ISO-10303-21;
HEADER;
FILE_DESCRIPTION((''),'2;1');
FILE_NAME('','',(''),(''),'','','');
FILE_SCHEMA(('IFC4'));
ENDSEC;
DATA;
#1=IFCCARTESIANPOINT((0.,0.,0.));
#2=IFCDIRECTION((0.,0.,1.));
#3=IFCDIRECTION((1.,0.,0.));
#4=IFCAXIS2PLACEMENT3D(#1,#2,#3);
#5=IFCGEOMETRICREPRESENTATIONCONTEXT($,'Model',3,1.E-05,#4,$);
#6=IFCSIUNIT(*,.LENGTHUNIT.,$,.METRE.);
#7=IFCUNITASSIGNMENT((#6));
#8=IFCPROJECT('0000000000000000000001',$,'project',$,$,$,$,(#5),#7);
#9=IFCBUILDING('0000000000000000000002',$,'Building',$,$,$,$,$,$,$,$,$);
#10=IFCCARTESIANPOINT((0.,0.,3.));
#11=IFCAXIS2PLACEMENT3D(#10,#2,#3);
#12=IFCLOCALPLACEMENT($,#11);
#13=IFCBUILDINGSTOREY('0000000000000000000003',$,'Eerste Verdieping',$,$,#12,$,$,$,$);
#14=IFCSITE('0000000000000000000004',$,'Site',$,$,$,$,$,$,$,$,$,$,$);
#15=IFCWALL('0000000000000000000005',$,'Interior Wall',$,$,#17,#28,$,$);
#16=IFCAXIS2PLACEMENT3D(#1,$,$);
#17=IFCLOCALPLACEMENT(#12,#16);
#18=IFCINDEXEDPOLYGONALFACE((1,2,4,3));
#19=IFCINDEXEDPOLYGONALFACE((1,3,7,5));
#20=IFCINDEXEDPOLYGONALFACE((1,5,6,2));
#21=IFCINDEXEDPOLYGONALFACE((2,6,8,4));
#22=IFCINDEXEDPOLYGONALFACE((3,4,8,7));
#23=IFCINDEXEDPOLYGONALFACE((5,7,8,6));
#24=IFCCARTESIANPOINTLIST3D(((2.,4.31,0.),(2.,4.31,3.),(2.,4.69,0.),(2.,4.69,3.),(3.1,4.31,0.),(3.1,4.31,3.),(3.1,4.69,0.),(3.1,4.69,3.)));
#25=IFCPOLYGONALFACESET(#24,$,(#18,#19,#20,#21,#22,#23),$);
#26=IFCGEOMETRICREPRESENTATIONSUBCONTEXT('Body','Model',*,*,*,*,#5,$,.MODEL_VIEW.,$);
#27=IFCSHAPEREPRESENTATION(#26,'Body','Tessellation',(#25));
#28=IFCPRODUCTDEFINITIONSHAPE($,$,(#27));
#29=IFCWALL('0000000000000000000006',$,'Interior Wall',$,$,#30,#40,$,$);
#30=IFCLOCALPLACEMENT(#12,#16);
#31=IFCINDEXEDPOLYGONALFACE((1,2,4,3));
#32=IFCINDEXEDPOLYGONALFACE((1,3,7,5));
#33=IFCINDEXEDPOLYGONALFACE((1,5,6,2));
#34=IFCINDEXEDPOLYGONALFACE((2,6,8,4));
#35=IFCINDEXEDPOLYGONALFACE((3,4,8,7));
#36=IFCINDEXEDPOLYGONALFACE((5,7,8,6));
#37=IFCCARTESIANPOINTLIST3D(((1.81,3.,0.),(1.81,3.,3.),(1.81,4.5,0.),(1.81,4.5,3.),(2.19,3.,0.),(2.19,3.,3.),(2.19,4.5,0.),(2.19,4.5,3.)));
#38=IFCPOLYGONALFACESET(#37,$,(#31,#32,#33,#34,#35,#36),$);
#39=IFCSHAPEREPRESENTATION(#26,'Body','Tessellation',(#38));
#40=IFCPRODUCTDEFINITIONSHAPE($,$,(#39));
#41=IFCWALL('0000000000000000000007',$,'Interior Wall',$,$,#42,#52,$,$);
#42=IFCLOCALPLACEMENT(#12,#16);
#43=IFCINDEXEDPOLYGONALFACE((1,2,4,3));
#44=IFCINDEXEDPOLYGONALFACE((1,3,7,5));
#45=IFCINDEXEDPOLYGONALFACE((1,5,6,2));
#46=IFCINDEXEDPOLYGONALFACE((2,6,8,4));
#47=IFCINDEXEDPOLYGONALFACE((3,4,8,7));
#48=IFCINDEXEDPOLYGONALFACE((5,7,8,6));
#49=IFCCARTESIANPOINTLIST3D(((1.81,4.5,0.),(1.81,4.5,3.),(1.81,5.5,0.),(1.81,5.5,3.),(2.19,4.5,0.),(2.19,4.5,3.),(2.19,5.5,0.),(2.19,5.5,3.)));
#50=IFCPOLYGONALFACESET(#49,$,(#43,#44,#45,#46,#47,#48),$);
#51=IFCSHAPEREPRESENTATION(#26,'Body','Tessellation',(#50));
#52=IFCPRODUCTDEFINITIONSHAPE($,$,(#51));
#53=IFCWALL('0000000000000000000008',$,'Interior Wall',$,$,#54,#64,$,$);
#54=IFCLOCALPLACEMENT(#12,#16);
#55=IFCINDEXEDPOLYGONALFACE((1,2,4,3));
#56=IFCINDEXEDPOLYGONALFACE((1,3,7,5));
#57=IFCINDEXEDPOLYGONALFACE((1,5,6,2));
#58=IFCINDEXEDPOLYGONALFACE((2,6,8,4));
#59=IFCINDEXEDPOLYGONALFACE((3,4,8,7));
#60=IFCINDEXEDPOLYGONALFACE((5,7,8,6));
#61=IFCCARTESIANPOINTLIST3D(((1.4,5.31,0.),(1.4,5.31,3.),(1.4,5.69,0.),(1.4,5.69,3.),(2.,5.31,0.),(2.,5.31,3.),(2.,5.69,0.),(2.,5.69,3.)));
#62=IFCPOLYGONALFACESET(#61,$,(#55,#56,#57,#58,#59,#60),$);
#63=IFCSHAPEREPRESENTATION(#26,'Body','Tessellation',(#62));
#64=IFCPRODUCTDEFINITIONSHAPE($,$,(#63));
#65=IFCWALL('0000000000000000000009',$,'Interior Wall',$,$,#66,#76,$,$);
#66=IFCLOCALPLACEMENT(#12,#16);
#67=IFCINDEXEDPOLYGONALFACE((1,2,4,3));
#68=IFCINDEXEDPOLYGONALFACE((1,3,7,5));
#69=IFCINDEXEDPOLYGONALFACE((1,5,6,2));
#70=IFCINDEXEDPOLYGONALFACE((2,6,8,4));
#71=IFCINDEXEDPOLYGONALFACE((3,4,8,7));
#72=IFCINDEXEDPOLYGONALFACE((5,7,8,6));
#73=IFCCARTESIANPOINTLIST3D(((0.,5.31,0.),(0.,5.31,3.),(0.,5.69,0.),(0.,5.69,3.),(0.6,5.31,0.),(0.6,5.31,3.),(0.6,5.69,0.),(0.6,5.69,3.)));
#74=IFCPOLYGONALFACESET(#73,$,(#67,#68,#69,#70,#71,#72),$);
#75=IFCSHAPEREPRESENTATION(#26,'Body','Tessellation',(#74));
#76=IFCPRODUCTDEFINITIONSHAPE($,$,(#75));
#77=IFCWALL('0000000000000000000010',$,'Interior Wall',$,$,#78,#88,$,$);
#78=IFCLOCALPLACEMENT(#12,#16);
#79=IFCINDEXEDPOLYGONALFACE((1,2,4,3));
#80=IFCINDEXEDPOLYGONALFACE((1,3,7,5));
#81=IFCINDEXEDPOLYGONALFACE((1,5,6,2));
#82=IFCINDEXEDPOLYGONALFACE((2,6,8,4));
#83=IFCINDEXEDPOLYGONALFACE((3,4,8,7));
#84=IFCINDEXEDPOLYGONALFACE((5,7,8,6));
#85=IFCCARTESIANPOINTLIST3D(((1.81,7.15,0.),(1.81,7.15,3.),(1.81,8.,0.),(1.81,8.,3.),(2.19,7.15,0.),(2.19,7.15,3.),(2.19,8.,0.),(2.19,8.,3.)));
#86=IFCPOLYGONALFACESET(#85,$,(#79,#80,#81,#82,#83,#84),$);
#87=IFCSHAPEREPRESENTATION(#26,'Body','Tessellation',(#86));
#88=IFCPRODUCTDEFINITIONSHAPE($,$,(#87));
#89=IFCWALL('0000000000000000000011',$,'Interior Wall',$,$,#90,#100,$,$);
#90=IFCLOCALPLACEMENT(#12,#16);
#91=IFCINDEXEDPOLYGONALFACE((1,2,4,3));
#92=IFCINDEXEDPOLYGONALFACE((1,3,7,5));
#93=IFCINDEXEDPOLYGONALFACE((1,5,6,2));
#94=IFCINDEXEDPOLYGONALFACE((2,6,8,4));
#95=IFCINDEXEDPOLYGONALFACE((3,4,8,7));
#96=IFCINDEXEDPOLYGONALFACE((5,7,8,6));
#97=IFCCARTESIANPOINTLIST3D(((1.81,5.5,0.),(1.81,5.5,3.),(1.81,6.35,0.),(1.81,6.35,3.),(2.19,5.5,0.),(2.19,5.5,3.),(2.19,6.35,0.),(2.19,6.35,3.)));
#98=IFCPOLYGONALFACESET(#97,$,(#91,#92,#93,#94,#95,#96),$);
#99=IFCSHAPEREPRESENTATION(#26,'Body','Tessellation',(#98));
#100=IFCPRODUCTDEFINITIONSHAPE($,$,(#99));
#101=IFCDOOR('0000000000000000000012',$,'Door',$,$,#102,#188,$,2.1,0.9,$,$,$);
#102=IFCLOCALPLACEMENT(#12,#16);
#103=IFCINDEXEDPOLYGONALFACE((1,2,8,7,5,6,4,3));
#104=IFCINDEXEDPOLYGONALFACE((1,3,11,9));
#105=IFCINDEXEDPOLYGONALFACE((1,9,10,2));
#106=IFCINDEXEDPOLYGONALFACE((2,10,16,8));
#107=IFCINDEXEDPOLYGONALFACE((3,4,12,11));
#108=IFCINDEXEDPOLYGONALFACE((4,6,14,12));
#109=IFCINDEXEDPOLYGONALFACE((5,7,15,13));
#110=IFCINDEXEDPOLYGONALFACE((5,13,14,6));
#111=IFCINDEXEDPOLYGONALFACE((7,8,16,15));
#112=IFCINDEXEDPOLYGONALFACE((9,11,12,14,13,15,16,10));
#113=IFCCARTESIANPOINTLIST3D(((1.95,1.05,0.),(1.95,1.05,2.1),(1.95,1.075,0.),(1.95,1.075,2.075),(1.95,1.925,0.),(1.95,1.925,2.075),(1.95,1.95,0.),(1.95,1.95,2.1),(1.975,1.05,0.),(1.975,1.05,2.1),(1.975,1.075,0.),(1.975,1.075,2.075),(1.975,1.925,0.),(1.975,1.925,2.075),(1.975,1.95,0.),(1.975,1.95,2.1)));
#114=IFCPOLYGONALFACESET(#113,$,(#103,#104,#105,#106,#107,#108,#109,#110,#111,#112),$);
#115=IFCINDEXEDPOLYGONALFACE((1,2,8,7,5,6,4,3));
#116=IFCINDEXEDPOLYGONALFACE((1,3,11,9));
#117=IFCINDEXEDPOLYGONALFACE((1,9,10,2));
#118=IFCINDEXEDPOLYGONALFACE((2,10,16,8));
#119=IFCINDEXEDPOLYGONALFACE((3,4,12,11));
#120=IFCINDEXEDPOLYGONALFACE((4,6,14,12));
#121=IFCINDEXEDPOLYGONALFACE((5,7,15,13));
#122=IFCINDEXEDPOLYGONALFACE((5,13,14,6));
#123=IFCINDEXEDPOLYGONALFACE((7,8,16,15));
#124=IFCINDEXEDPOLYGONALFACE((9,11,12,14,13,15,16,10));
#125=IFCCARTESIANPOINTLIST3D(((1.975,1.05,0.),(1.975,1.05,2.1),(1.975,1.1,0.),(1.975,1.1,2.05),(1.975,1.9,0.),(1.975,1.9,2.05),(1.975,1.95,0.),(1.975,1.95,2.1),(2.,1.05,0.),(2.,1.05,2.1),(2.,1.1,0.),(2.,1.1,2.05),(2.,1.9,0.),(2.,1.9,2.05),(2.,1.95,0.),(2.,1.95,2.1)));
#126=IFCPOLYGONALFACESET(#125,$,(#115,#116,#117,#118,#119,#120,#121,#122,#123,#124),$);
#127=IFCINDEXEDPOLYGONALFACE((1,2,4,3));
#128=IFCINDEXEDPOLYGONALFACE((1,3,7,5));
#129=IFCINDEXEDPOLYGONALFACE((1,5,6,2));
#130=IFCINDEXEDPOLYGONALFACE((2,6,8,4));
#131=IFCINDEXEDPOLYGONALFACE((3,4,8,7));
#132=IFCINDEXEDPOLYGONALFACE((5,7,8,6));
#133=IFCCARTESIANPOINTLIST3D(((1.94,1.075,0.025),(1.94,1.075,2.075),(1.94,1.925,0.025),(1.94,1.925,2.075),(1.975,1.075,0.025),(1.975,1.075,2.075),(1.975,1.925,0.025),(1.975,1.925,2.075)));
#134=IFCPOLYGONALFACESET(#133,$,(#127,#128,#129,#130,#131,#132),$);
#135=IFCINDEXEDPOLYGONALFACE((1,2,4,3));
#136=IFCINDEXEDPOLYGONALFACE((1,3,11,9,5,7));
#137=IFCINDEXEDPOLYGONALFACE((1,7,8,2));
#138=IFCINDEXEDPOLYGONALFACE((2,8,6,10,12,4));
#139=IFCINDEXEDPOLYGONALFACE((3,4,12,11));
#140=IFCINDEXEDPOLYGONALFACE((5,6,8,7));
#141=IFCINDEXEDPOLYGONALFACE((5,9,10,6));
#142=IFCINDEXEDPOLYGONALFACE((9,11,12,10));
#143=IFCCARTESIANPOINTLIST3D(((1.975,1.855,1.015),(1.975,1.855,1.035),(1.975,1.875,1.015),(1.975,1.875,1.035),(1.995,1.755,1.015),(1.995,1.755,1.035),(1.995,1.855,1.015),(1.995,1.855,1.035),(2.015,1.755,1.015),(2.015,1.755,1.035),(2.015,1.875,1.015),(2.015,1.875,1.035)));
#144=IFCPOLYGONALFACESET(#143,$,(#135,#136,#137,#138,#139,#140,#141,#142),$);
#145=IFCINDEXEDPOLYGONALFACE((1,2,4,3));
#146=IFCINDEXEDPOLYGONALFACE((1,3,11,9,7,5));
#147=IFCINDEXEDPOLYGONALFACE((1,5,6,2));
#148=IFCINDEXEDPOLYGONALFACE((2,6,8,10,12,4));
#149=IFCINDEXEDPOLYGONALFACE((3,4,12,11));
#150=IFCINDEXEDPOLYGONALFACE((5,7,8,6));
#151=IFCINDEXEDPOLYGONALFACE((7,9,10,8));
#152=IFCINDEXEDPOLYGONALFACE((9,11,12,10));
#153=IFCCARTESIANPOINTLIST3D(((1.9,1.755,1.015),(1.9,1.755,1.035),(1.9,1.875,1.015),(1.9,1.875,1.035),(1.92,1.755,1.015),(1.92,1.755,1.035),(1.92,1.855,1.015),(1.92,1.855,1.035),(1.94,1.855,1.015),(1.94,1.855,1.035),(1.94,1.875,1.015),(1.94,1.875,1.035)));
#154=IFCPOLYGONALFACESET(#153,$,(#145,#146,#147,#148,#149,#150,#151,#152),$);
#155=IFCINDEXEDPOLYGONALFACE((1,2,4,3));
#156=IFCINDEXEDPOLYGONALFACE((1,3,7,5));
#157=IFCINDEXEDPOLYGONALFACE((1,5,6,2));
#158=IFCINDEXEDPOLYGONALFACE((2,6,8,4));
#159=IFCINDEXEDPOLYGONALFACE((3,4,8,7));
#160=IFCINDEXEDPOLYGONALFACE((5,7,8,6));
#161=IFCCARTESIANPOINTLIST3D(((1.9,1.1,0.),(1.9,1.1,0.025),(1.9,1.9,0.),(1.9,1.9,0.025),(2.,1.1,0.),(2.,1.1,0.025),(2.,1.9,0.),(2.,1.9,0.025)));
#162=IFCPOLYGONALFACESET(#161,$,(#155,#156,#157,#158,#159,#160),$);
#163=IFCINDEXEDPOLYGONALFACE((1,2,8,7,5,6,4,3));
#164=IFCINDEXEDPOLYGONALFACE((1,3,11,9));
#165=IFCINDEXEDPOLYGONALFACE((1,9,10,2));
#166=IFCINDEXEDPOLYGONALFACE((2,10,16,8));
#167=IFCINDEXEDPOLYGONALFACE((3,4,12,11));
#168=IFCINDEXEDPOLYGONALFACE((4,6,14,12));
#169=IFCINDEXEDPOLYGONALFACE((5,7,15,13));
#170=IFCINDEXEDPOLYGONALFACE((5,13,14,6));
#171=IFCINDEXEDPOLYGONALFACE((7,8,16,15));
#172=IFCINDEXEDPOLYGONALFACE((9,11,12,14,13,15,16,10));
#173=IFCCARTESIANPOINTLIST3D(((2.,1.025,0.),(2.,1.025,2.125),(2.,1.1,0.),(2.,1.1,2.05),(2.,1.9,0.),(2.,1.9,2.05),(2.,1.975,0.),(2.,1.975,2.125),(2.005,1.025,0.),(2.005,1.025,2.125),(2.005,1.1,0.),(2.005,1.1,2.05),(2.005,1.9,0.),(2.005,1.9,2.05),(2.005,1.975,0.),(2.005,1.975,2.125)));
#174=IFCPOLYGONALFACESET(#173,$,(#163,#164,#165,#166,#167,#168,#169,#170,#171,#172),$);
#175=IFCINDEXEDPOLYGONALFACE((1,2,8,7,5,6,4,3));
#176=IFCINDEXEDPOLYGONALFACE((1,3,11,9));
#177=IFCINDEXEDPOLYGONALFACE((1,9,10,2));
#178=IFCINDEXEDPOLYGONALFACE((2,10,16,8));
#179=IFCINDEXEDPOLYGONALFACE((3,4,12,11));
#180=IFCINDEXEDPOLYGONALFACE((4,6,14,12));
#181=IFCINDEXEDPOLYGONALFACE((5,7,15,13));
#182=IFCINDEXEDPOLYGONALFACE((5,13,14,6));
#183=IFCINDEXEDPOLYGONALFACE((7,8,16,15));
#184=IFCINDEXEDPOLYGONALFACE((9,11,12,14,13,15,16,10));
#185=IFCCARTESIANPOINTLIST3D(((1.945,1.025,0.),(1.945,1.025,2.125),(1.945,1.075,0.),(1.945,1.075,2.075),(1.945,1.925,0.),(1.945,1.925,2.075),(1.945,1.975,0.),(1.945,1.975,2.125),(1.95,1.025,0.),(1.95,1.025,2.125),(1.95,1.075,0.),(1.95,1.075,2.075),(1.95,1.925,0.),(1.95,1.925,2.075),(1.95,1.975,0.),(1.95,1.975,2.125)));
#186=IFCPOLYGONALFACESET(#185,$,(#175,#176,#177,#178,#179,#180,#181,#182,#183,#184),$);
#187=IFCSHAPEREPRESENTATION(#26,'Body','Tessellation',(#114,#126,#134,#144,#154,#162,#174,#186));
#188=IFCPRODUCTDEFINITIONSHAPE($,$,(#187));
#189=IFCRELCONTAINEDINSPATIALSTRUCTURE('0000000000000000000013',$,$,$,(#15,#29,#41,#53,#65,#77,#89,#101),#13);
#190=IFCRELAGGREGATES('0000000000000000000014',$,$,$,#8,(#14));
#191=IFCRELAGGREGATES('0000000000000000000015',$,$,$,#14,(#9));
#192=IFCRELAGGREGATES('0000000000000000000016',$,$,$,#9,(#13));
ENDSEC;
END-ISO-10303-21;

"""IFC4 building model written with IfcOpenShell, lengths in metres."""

from ifc_helpers import new_model, si_unit, frame, origin_with_axes, place, context, subcontext, project, spatial, line, indexed_curve, outline, extrude, element, save


model = new_model("IFC4")

# Units and contexts
model_context = context("Model", 3, precision=1e-05, world=origin_with_axes())
body_context = subcontext(model_context, "Body", "Model", "MODEL_VIEW")
ifc_project = project(units=[si_unit("LENGTHUNIT", "METRE")], contexts=[model_context])

# Site, building, storey
site = spatial("IfcSite", under=ifc_project, Name="Site")
building = spatial("IfcBuilding", under=site, Name="Building")
storey_placement = place(None, frame((0.0, 0.0, 3.0), z_axis=(0.0, 0.0, 1.0), x_axis=(1.0, 0.0, 0.0)))
storey = spatial("IfcBuildingStorey", under=building, at=storey_placement, Name="Eerste Verdieping")

# Walls
for number, where, z_axis, x_axis, name in (
    (1, (3.1, 4.5, 0.0), (0.0, 0.0, 1.0), (-1.0, 0.0, 0.0), "Interior Wall"),
):
    element("IfcWall", number, at=place(storey_placement, frame(where, z_axis=z_axis, x_axis=x_axis)), inside=storey, Name=name, context=body_context, shape_type="SweptSolid", body=[
        extrude(outline(indexed_curve([(0.0, 0.0), (0.0, 0.38), (1.1, 0.38), (1.1, 0.0), (0.0, 0.0)], self_intersect=False)), frame((0.0, -0.19, 0.0), z_axis=(0.0, 0.0, 1.0), x_axis=(1.0, 0.0, 0.0)), (0.0, 0.0, 1.0), 3.0),
    ])
wall_1_placement = place(storey_placement, frame((2.0, 4.5, 0.0), z_axis=(0.0, 0.0, 1.0), x_axis=(0.0, -1.0, 0.0)))
element("IfcWall", 2, at=wall_1_placement, inside=storey, Name="Interior Wall", context=body_context, shape_type="SweptSolid", body=[
    extrude(outline(indexed_curve([(0.0, 0.0), (0.0, 0.38), (1.5, 0.38), (1.5, 0.0), (0.0, 0.0)], self_intersect=False)), frame((0.0, -0.19, 0.0), z_axis=(0.0, 0.0, 1.0), x_axis=(1.0, 0.0, 0.0)), (0.0, 0.0, 1.0), 3.0),
])
wall_2_placement = place(storey_placement, frame((2.0, 4.5, 0.0), z_axis=(0.0, 0.0, 1.0), x_axis=(0.0, 1.0, 0.0)))
element("IfcWall", 3, at=wall_2_placement, inside=storey, Name="Interior Wall", context=body_context, shape_type="SweptSolid", body=[
    extrude(outline(indexed_curve([(0.0, 0.0), (0.0, 0.38), (1.0, 0.38), (1.0, 0.0), (0.0, 0.0)], self_intersect=False)), frame((0.0, -0.19, 0.0), z_axis=(0.0, 0.0, 1.0), x_axis=(1.0, 0.0, 0.0)), (0.0, 0.0, 1.0), 3.0),
])
for number, where, z_axis, x_axis, name in (
    (4, (2.0, 5.5, 0.0), (0.0, 0.0, 1.0), (-1.0, 0.0, 0.0), "Interior Wall"),
    (5, (0.6, 5.5, 0.0), (0.0, 0.0, 1.0), (-1.0, 0.0, 0.0), "Interior Wall"),
):
    element("IfcWall", number, at=place(storey_placement, frame(where, z_axis=z_axis, x_axis=x_axis)), inside=storey, Name=name, context=body_context, shape_type="SweptSolid", body=[
        extrude(outline(indexed_curve([(0.0, 0.0), (0.0, 0.38), (0.6, 0.38), (0.6, 0.0), (0.0, 0.0)], self_intersect=False)), frame((0.0, -0.19, 0.0), z_axis=(0.0, 0.0, 1.0), x_axis=(1.0, 0.0, 0.0)), (0.0, 0.0, 1.0), 3.0),
    ])
for number, where, z_axis, x_axis, name in (
    (6, (2.0, 8.0, 0.0), (0.0, 0.0, 1.0), (0.0, -1.0, 0.0), "Interior Wall"),
    (7, (2.0, 6.35, 0.0), (0.0, 0.0, 1.0), (0.0, -1.0, 0.0), "Interior Wall"),
):
    element("IfcWall", number, at=place(storey_placement, frame(where, z_axis=z_axis, x_axis=x_axis)), inside=storey, Name=name, context=body_context, shape_type="SweptSolid", body=[
        extrude(outline(indexed_curve([(0.0, 0.0), (0.0, 0.38), (0.85, 0.38), (0.85, 0.0), (0.0, 0.0)], self_intersect=False)), frame((0.0, -0.19, 0.0), z_axis=(0.0, 0.0, 1.0), x_axis=(1.0, 0.0, 0.0)), (0.0, 0.0, 1.0), 3.0),
    ])

# Door
door_1_placement = place(storey_placement, frame((2.0, 1.05, 0.0), z_axis=(0.0, 0.0, 1.0), x_axis=(0.0, 1.0, 0.0)))
element("IfcDoor", 8, at=door_1_placement, inside=storey, Name="Door", OverallHeight=2.1, OverallWidth=0.9, context=body_context, shape_type="SweptSolid", body=[
    extrude(outline(indexed_curve([(0.0, 0.0), (0.0, 2.1), (0.9, 2.1), (0.9, 0.0), (0.875, 0.0), (0.875, 2.075), (0.025, 2.075), (0.025, 0.0)], segments=[line(1, 2, 3, 4, 5, 6, 7, 8, 1)])), frame((0.0, 0.025, 0.0), z_axis=(0.0, -1.0, 0.0), x_axis=(1.0, 0.0, 0.0)), (0.0, 0.0, -1.0), 0.025),
    extrude(outline(indexed_curve([(0.0, 0.0), (0.0, 2.1), (0.9, 2.1), (0.9, 0.0), (0.85, 0.0), (0.85, 2.05), (0.05, 2.05), (0.05, 0.0)], segments=[line(1, 2, 3, 4, 5, 6, 7, 8, 1)])), frame((0.0, 0.0, 0.0), z_axis=(0.0, -1.0, 0.0), x_axis=(1.0, 0.0, 0.0)), (0.0, 0.0, -1.0), 0.025),
    extrude(outline(indexed_curve([(0.0, 0.0), (0.85, 0.0), (0.85, 0.035), (0.0, 0.035)], segments=[line(1, 2, 3, 4, 1)])), frame((0.025, 0.025, 0.025), z_axis=(0.0, 0.0, 1.0), x_axis=(1.0, 0.0, 0.0)), (0.0, 0.0, 1.0), 2.05),
    extrude(outline(indexed_curve([(0.0, 0.0), (0.0, -0.04), (-0.12, -0.04), (-0.12, -0.02), (-0.02, -0.02), (-0.02, 0.0)], segments=[line(1, 2, 3, 4, 5, 6, 1)])), frame((0.825, 0.025, 1.015), z_axis=(0.0, 0.0, 1.0), x_axis=(1.0, 0.0, 0.0)), (0.0, 0.0, 1.0), 0.02),
    extrude(outline(indexed_curve([(0.0, 0.0), (0.0, 0.04), (-0.12, 0.04), (-0.12, 0.02), (-0.02, 0.02), (-0.02, 0.0)], segments=[line(1, 2, 3, 4, 5, 6, 1)])), frame((0.825, 0.06, 1.015), z_axis=(0.0, 0.0, 1.0), x_axis=(1.0, 0.0, 0.0)), (0.0, 0.0, 1.0), 0.02),
    extrude(outline(indexed_curve([(0.0, 0.0), (0.8, 0.0), (0.8, 0.1), (0.0, 0.1)], segments=[line(1, 2, 3, 4, 1)])), frame((0.05, 0.0, 0.0), z_axis=(0.0, 0.0, 1.0), x_axis=(1.0, 0.0, 0.0)), (0.0, 0.0, 1.0), 0.025),
    extrude(outline(indexed_curve([(0.0, 0.0), (0.0, 2.125), (0.95, 2.125), (0.95, 0.0), (0.875, 0.0), (0.875, 2.05), (0.075, 2.05), (0.075, 0.0)], segments=[line(1, 2, 3, 4, 5, 6, 7, 8, 1)])), frame((-0.025, -0.005, 0.0), z_axis=(0.0, -1.0, 0.0), x_axis=(1.0, 0.0, 0.0)), (0.0, 0.0, -1.0), 0.005),
    extrude(outline(indexed_curve([(0.0, 0.0), (0.0, 2.125), (0.95, 2.125), (0.95, 0.0), (0.9, 0.0), (0.9, 2.075), (0.05, 2.075), (0.05, 0.0)], segments=[line(1, 2, 3, 4, 5, 6, 7, 8, 1)])), frame((-0.025, 0.05, 0.0), z_axis=(0.0, -1.0, 0.0), x_axis=(1.0, 0.0, 0.0)), (0.0, 0.0, -1.0), 0.005),
])

save(model, "model.ifc")
